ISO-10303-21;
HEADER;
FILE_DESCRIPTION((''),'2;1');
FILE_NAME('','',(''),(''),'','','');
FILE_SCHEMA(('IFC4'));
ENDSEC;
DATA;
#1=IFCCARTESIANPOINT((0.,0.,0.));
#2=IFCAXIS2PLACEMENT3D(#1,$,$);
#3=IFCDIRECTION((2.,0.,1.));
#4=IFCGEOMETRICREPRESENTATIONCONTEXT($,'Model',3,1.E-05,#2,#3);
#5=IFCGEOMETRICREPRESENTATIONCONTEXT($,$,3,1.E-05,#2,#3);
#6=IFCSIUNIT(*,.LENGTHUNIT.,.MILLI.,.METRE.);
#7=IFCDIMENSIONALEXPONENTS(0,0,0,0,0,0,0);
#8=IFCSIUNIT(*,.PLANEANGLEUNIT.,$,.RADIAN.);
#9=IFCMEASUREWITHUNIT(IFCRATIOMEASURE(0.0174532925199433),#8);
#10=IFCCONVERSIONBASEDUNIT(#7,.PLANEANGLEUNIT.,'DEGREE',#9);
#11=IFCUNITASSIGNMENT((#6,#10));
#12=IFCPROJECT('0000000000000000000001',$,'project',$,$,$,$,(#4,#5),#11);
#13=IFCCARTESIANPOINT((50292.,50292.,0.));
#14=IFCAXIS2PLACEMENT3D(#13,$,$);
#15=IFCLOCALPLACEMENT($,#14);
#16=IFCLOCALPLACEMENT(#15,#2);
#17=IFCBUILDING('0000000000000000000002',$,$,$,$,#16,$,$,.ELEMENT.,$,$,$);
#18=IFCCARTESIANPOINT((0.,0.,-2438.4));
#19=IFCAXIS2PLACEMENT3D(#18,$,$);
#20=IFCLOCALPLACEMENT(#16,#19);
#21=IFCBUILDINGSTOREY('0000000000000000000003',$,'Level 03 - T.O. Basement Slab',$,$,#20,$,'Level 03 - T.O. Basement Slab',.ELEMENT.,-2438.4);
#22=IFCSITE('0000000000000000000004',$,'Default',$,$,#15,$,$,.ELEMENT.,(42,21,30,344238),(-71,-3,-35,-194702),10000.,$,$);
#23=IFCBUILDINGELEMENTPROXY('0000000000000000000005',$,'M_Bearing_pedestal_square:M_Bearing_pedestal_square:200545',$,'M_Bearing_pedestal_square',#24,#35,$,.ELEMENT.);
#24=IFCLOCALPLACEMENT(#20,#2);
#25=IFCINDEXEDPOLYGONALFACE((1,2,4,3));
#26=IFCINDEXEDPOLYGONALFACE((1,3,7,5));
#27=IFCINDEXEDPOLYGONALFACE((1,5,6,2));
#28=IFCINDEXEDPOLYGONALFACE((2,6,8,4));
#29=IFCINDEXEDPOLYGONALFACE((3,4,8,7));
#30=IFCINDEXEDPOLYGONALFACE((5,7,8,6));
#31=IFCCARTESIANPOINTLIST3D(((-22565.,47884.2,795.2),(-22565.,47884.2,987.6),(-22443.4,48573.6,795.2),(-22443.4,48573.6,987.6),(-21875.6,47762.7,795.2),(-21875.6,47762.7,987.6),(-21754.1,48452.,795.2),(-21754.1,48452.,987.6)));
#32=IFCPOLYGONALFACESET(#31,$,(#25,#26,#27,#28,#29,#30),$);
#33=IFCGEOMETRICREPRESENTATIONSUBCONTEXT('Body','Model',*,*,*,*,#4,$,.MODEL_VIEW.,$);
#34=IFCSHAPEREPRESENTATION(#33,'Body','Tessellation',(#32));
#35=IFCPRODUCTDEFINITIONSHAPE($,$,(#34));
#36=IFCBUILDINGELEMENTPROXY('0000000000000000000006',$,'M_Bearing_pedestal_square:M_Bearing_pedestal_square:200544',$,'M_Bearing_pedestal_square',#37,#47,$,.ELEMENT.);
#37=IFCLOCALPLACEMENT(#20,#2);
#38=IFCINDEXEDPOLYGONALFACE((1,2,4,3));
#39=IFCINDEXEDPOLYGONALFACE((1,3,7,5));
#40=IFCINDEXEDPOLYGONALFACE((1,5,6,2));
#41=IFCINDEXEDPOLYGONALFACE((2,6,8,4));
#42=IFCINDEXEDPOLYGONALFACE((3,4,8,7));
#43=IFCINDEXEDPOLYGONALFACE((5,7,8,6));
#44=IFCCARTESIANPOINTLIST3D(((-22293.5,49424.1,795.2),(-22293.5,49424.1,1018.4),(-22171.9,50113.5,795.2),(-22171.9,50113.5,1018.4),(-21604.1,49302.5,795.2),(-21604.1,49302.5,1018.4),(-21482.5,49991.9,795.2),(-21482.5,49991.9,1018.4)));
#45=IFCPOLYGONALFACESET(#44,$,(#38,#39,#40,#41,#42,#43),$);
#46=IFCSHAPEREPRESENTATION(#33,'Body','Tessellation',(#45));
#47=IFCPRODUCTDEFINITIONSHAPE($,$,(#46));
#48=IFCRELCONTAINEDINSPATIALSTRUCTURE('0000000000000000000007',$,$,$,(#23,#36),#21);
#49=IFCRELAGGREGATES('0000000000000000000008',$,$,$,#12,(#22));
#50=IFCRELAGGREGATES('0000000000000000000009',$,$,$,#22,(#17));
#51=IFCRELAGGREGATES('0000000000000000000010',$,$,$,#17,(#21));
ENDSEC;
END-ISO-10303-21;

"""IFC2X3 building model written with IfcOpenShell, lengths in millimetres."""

from ifc_helpers import new_model, entity, si_unit, converted_unit, direction, frame, origin, origin_2d_with_axis, place, context, subcontext, project, spatial, rectangle, extrude, source, transform, mapped, element, save


model = new_model("IFC2X3")

# Units and contexts
model_context = context("Model", 3, precision=1e-05, world=origin(), true_north=direction((2.0, 0.0, 1.0)))
context_of_model = context(None, 3, precision=1e-05, world=origin(), true_north=direction((2.0, 0.0, 1.0)))
body_context = subcontext(model_context, "Body", "Model", "MODEL_VIEW")
ifc_project = project(units=[si_unit("LENGTHUNIT", "METRE", prefix="MILLI"), converted_unit("PLANEANGLEUNIT", "DEGREE", entity("IfcRatioMeasure", 0.0174532925199433), si_unit("PLANEANGLEUNIT", "RADIAN"), dimensions=[0, 0, 0, 0, 0, 0, 0])], contexts=[model_context, context_of_model])

# Site, building, storey
site_placement = place(None, frame((50292.0, 50292.0, 0.0)))
site = spatial("IfcSite", under=ifc_project, at=site_placement, Name="Default", CompositionType="ELEMENT", RefLatitude=(42, 21, 30, 344238), RefLongitude=(-71, -3, -35, -194702), RefElevation=10000.0)
building_placement = place(site_placement, origin())
building = spatial("IfcBuilding", under=site, at=building_placement, CompositionType="ELEMENT")
storey_placement = place(building_placement, frame((0.0, 0.0, -2438.4)))
storey = spatial("IfcBuildingStorey", under=building, at=storey_placement, Name="Level 03 - T.O. Basement Slab", LongName="Level 03 - T.O. Basement Slab", CompositionType="ELEMENT", Elevation=-2438.4)

# Building element proxies
shared_shape_1 = source(origin(), body_context, "Body", "SweptSolid", [
    extrude(rectangle(XDim=700.0, YDim=700.0, at=origin_2d_with_axis()), frame((0.0, 0.0, -192.4)), (0.0, 0.0, 1.0), 192.4),
])
proxy_1_placement = place(storey_placement, frame((-22159.5, 48168.1, 987.6), z_axis=(0.0, 0.0, 1.0), x_axis=(0.173648, 0.984808, 0.0)))
element("IfcBuildingElementProxy", 1, at=proxy_1_placement, inside=storey, Name="M_Bearing_pedestal_square:M_Bearing_pedestal_square:200545", ObjectType="M_Bearing_pedestal_square", CompositionType="ELEMENT", context=body_context, shape_type="MappedRepresentation", body=[
    mapped(shared_shape_1, transform((0.0, 0.0, 0.0), scale=1.0)),
])
shared_shape_2 = source(origin(), body_context, "Body", "SweptSolid", [
    extrude(rectangle(XDim=700.0, YDim=700.0, at=origin_2d_with_axis()), frame((0.0, 0.0, -223.2)), (0.0, 0.0, 1.0), 223.2),
])
proxy_2_placement = place(storey_placement, frame((-21888.0, 49708.0, 1018.4), z_axis=(0.0, 0.0, 1.0), x_axis=(0.173648, 0.984808, 0.0)))
element("IfcBuildingElementProxy", 2, at=proxy_2_placement, inside=storey, Name="M_Bearing_pedestal_square:M_Bearing_pedestal_square:200544", ObjectType="M_Bearing_pedestal_square", CompositionType="ELEMENT", context=body_context, shape_type="MappedRepresentation", body=[
    mapped(shared_shape_2, transform((0.0, 0.0, 0.0), scale=1.0)),
])

save(model, "model.ifc")
